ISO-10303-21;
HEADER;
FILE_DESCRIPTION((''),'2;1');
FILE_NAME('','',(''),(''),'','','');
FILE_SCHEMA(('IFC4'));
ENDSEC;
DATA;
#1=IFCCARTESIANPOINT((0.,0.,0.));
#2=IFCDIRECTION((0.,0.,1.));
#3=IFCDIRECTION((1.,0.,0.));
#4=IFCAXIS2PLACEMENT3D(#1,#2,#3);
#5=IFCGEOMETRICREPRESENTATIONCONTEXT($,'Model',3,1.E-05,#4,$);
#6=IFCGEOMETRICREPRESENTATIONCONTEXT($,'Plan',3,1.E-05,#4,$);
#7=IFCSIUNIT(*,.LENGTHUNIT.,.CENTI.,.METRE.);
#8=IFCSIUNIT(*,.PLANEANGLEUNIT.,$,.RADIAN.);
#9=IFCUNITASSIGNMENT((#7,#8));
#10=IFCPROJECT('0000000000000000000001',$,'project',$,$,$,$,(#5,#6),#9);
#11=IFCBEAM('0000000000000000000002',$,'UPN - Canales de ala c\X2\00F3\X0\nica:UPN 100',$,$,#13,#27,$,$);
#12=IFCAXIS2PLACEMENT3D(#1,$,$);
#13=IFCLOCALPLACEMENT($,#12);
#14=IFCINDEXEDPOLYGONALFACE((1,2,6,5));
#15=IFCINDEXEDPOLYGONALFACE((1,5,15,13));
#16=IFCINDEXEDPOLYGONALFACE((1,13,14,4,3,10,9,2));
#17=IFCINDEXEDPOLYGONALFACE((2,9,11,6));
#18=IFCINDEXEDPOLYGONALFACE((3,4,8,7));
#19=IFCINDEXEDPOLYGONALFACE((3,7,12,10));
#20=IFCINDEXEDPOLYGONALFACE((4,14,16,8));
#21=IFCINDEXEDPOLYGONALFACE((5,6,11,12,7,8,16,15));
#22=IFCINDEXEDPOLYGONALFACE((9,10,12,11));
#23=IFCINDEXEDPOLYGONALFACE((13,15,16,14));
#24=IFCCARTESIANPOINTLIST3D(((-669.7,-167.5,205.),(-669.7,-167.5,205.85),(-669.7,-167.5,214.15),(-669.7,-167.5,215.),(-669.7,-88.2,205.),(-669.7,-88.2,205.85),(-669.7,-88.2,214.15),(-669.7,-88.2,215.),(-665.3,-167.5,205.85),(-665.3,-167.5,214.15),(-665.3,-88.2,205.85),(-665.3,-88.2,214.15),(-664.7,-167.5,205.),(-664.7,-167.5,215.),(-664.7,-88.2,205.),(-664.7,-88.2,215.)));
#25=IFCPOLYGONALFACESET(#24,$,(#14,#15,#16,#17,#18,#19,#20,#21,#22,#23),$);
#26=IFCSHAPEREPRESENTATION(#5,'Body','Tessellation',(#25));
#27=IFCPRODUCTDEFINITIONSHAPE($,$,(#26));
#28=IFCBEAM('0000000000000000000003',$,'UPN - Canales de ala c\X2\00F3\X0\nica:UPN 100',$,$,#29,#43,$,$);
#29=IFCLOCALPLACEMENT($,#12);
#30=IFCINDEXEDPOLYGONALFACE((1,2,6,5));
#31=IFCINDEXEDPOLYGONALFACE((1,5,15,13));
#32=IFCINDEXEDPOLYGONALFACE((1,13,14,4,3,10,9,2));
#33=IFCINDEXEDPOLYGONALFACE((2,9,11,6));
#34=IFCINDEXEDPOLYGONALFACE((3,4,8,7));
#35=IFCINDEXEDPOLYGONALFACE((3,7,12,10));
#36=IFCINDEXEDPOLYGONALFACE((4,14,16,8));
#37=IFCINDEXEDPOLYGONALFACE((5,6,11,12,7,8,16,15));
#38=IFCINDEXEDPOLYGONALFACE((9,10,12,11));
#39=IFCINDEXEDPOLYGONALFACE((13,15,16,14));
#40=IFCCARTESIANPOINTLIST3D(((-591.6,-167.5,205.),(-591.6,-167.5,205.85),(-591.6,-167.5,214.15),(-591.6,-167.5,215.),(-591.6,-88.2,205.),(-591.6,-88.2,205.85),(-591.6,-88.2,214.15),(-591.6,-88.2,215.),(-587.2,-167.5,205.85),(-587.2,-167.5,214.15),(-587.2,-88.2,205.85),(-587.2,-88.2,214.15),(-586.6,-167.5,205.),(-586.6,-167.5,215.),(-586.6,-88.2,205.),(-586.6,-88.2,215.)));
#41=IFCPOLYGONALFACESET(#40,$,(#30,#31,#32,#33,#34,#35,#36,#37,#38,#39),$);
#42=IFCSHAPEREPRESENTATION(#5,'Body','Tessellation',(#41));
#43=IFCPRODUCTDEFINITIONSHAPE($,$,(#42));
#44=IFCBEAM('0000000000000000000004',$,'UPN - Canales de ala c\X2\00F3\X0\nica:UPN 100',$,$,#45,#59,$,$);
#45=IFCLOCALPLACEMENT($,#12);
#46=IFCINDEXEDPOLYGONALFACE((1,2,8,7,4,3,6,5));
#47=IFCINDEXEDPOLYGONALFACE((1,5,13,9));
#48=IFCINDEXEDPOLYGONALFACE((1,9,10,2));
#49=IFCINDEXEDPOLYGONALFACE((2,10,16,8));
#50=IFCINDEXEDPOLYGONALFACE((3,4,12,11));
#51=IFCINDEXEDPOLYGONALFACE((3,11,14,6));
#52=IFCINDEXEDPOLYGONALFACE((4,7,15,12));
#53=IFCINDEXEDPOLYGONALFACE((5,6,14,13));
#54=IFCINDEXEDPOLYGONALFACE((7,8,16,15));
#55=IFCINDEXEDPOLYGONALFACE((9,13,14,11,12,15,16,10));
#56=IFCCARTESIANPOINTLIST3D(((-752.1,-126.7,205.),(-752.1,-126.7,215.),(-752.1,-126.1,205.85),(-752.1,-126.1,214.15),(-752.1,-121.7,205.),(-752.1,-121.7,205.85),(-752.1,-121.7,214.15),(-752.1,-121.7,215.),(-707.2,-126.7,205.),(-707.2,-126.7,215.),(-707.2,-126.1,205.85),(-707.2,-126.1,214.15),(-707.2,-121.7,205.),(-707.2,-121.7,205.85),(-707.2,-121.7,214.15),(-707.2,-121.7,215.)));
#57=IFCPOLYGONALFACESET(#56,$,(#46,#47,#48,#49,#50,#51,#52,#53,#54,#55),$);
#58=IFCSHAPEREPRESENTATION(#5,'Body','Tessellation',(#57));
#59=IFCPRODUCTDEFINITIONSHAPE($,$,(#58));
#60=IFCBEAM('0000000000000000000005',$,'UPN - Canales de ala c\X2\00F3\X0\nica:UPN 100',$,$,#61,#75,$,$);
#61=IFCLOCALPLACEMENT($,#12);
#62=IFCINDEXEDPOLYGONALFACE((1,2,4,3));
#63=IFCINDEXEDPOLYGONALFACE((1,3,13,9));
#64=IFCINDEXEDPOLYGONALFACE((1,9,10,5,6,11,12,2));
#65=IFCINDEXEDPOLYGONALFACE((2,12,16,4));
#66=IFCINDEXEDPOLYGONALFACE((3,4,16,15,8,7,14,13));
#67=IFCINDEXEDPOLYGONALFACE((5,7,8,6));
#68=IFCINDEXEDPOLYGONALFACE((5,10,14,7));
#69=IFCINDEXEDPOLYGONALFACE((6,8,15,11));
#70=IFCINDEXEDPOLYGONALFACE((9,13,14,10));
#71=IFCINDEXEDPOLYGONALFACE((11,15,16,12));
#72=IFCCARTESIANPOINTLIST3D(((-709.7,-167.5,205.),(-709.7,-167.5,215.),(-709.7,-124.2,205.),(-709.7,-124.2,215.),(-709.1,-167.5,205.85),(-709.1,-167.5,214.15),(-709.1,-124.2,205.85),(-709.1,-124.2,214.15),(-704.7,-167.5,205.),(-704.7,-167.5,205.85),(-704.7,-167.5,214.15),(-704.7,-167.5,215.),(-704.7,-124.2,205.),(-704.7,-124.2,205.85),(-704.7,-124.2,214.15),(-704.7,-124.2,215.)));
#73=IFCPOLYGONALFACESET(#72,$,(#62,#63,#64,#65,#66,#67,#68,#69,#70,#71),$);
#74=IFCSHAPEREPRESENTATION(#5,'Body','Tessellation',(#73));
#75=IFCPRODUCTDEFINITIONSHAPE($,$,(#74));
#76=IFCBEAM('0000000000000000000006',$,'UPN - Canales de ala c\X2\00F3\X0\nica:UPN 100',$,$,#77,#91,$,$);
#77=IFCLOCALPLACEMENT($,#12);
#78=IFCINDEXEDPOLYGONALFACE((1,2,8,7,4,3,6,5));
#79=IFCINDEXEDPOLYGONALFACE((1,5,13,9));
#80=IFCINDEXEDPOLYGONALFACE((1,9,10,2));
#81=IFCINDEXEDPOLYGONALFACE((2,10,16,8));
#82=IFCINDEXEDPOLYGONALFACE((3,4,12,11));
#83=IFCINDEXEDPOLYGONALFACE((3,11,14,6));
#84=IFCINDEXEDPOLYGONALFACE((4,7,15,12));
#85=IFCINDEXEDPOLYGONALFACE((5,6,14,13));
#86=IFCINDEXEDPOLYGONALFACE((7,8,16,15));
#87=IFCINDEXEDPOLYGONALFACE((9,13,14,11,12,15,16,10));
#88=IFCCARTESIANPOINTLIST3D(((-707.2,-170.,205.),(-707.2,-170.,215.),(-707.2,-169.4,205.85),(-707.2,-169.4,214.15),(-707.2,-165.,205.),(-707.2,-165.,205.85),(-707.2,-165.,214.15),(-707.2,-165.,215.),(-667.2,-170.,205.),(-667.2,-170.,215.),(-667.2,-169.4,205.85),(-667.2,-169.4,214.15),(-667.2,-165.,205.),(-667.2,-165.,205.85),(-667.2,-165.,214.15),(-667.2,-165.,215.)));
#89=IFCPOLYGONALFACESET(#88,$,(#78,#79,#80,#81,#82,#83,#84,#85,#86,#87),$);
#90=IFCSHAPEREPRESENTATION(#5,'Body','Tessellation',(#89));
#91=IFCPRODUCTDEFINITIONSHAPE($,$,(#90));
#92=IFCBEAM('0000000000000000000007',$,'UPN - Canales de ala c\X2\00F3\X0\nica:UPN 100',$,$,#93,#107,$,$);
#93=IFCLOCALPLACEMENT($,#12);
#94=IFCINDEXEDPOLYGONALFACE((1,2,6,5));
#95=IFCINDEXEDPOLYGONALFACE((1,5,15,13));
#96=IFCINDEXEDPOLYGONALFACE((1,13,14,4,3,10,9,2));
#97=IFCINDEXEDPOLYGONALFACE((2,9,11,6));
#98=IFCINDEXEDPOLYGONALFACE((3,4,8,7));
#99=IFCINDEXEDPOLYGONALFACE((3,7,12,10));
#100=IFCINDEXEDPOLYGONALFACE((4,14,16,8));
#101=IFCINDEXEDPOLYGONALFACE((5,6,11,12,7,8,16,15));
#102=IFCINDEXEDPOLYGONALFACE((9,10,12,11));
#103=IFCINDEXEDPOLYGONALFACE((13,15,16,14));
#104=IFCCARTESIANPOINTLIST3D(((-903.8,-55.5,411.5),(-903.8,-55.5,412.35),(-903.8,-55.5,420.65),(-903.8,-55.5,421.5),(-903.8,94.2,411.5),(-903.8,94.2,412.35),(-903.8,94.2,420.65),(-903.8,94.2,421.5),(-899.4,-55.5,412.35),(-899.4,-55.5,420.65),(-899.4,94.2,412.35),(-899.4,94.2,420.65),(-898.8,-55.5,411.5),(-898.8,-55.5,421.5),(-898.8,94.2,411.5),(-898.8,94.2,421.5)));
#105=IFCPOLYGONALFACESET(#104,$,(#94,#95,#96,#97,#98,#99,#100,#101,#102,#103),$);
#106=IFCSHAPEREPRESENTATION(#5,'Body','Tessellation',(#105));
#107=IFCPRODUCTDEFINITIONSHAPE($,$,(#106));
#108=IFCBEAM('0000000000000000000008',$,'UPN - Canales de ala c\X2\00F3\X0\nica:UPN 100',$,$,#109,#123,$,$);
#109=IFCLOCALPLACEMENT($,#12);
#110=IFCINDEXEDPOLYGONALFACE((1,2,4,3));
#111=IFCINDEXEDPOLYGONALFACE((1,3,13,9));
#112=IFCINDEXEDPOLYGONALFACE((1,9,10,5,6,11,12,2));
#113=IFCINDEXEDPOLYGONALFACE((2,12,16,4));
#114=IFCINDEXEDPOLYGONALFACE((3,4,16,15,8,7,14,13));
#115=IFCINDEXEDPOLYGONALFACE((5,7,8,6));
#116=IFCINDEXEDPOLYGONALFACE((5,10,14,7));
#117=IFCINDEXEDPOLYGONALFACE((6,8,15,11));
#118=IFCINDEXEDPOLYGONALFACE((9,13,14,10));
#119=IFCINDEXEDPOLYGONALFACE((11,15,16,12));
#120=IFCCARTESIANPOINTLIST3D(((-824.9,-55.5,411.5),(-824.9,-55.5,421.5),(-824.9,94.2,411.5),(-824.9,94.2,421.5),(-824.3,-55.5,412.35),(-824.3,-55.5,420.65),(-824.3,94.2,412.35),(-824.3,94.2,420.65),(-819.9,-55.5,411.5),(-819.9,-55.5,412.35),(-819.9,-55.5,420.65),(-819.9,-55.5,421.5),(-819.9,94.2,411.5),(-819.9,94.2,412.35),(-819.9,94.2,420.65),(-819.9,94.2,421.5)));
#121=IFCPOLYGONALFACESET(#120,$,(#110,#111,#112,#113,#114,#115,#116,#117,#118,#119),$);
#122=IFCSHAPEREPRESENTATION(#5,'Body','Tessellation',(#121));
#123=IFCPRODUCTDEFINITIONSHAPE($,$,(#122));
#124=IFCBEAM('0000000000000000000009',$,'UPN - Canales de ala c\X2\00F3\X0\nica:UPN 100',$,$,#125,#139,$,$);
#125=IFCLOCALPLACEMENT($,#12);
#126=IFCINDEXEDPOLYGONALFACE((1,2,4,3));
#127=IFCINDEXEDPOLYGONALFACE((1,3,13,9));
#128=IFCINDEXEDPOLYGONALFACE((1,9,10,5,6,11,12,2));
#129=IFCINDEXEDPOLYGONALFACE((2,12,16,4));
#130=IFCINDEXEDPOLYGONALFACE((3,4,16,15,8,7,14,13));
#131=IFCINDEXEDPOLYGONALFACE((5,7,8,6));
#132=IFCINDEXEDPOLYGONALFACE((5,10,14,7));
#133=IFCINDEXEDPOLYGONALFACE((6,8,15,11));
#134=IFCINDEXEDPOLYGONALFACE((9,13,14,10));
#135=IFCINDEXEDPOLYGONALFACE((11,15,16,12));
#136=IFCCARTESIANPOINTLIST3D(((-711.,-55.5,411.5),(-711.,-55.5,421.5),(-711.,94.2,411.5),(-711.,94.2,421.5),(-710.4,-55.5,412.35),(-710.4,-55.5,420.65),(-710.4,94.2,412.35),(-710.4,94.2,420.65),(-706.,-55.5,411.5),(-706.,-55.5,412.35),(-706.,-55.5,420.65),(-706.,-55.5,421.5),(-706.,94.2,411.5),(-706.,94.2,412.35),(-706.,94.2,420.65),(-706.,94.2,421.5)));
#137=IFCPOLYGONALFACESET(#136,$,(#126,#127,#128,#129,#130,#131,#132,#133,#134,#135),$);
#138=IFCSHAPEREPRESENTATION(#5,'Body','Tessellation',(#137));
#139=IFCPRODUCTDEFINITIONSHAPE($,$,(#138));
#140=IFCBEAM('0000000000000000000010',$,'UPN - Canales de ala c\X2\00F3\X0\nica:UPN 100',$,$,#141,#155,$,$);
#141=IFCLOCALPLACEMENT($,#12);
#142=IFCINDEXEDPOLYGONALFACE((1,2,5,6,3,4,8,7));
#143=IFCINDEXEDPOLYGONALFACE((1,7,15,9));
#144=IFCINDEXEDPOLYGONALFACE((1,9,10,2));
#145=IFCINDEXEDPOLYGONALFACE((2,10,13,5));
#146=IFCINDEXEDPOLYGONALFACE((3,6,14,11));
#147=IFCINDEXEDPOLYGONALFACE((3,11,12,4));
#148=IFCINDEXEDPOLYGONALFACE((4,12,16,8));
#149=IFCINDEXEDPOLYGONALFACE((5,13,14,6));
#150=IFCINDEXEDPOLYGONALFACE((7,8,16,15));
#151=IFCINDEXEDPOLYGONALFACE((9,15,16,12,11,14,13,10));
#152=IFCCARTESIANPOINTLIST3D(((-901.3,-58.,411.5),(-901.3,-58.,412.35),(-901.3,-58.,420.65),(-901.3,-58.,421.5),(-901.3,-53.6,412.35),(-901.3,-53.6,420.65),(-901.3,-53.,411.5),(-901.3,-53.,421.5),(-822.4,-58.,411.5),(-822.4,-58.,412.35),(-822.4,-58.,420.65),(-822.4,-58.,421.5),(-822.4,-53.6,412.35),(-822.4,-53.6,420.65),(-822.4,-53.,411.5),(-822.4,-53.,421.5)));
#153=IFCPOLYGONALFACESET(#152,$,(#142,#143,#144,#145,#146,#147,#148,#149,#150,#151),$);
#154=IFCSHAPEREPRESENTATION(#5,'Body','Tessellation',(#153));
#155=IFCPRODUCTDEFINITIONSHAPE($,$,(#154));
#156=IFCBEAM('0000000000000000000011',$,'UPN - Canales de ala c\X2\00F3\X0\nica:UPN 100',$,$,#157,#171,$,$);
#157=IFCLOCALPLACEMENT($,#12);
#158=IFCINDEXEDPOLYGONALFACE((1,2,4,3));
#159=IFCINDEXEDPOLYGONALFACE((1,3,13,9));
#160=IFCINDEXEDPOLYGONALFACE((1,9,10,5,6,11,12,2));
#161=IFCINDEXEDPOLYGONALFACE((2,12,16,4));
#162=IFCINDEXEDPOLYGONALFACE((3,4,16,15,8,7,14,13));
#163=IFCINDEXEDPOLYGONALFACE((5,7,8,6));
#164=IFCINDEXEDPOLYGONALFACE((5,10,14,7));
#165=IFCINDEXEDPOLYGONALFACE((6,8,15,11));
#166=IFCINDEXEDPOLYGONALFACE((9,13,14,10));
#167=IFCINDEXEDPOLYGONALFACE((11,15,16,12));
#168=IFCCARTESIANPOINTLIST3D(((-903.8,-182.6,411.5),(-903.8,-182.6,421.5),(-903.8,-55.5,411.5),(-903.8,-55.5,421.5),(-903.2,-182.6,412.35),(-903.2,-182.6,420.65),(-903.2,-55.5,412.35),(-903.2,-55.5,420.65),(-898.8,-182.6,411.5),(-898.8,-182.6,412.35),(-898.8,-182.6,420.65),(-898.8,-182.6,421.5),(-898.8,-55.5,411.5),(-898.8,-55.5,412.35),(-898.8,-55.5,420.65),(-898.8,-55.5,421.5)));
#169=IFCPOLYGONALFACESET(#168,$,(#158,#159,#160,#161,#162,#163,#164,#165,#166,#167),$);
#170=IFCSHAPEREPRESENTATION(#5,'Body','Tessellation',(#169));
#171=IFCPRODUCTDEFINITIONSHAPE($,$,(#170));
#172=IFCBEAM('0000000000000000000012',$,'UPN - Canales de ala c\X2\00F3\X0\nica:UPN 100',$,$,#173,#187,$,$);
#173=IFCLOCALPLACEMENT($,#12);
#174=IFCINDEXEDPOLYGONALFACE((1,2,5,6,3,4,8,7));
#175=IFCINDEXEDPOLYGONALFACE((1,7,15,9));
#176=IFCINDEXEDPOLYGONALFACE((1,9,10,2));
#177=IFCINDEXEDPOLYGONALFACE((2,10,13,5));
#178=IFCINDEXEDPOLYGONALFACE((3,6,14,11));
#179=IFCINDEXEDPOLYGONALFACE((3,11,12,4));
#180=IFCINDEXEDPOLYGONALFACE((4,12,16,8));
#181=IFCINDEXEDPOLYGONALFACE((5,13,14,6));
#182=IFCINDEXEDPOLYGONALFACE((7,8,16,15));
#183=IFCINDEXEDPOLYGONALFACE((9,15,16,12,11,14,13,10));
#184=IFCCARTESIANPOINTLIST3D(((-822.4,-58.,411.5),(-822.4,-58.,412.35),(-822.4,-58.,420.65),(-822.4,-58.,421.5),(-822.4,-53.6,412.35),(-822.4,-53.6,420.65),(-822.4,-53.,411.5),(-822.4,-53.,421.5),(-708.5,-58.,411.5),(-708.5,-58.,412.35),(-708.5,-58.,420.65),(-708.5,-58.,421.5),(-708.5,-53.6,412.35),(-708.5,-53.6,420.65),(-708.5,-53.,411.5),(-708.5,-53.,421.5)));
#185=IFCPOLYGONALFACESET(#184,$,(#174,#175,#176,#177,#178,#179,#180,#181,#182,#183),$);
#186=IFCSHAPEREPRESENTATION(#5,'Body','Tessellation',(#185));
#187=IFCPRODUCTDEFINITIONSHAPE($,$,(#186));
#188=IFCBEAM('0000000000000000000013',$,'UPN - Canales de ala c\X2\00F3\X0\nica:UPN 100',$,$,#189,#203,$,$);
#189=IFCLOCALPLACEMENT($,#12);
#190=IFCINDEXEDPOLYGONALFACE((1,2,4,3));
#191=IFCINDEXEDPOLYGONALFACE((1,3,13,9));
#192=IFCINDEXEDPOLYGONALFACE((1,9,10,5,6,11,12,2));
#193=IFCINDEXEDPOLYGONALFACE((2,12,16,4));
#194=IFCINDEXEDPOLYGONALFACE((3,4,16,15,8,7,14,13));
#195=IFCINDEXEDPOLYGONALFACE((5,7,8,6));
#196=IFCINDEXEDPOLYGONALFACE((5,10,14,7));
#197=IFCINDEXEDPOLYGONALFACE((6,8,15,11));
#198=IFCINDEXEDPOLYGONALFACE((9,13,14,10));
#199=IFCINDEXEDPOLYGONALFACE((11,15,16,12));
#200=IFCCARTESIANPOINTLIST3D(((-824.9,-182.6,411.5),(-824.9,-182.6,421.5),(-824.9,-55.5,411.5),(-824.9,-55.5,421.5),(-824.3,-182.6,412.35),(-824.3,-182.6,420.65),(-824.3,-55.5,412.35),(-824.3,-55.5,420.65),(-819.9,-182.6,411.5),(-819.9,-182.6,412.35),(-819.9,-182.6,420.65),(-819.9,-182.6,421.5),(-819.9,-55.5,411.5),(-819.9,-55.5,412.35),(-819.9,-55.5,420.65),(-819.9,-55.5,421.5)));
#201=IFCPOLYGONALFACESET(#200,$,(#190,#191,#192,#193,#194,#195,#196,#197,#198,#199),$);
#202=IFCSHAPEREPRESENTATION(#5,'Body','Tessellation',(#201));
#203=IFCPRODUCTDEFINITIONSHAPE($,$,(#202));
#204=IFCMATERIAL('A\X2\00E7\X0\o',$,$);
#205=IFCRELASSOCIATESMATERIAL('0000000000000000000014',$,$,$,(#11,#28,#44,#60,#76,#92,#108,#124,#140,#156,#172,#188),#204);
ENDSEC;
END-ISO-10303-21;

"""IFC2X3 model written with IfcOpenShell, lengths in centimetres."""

from ifc_helpers import new_model, si_unit, frame, origin_with_axes, origin_2d_with_axis, place, context, project, u_section, extrude, material, element, save


model = new_model("IFC2X3")

# Units and contexts
model_context = context("Model", 3, precision=1e-05, world=origin_with_axes())
plan_context = context("Plan", 3, precision=1e-05, world=origin_with_axes())
ifc_project = project(units=[si_unit("LENGTHUNIT", "METRE", prefix="CENTI"), si_unit("PLANEANGLEUNIT", "RADIAN")], contexts=[model_context, plan_context])

# Shared definitions
ifc_material = material(Name="Aço")

# Beams
for number, where, z_axis, x_axis, name in (
    (1, (-667.2, -167.5, 210.0), (0.0, 1.0, 0.0), (-1.0, 0.0, 0.0), "UPN - Canales de ala cónica:UPN 100"),
    (2, (-589.1, -167.5, 210.0), (0.0, 1.0, 0.0), (-1.0, 0.0, 0.0), "UPN - Canales de ala cónica:UPN 100"),
):
    element("IfcBeam", number, at=place(None, frame(where, z_axis=z_axis, x_axis=x_axis)), material=ifc_material, Name=name, context=model_context, shape_type="SweptSolid", body=[
        extrude(u_section(Depth=10.0, FlangeWidth=5.0, WebThickness=0.6, FlangeThickness=0.85, FilletRadius=0.0, EdgeRadius=0.0, FlangeSlope=0.0, CentreOfGravityInX=0.0, at=origin_2d_with_axis()), origin_with_axes(), (0.0, 0.0, 1.0), 79.3),
    ])
beam_1_placement = place(None, frame((-707.2, -124.2, 210.0), z_axis=(-1.0, 0.0, 0.0), x_axis=(0.0, 1.0, 0.0)))
element("IfcBeam", 3, at=beam_1_placement, material=ifc_material, Name="UPN - Canales de ala cónica:UPN 100", context=model_context, shape_type="SweptSolid", body=[
    extrude(u_section(Depth=10.0, FlangeWidth=5.0, WebThickness=0.6, FlangeThickness=0.85, FilletRadius=0.0, EdgeRadius=0.0, FlangeSlope=0.0, CentreOfGravityInX=0.0, at=origin_2d_with_axis()), origin_with_axes(), (0.0, 0.0, 1.0), 44.9),
])
beam_2_placement = place(None, frame((-707.2, -167.5, 210.0), z_axis=(0.0, 1.0, 0.0), x_axis=(1.0, 0.0, 0.0)))
element("IfcBeam", 4, at=beam_2_placement, material=ifc_material, Name="UPN - Canales de ala cónica:UPN 100", context=model_context, shape_type="SweptSolid", body=[
    extrude(u_section(Depth=10.0, FlangeWidth=5.0, WebThickness=0.6, FlangeThickness=0.85, FilletRadius=0.0, EdgeRadius=0.0, FlangeSlope=0.0, CentreOfGravityInX=0.0, at=origin_2d_with_axis()), origin_with_axes(), (0.0, 0.0, 1.0), 43.3),
])
beam_3_placement = place(None, frame((-667.2, -167.5, 210.0), z_axis=(-1.0, 0.0, 0.0), x_axis=(0.0, 1.0, 0.0)))
element("IfcBeam", 5, at=beam_3_placement, material=ifc_material, Name="UPN - Canales de ala cónica:UPN 100", context=model_context, shape_type="SweptSolid", body=[
    extrude(u_section(Depth=10.0, FlangeWidth=5.0, WebThickness=0.6, FlangeThickness=0.85, FilletRadius=0.0, EdgeRadius=0.0, FlangeSlope=0.0, CentreOfGravityInX=0.0, at=origin_2d_with_axis()), origin_with_axes(), (0.0, 0.0, 1.0), 40.0),
])
for number, where, z_axis, x_axis, name in (
    (6, (-901.3, -55.5, 416.5), (0.0, 1.0, 0.0), (-1.0, 0.0, 0.0), "UPN - Canales de ala cónica:UPN 100"),
    (7, (-822.4, -55.5, 416.5), (0.0, 1.0, 0.0), (1.0, 0.0, 0.0), "UPN - Canales de ala cónica:UPN 100"),
    (8, (-708.5, -55.5, 416.5), (0.0, 1.0, 0.0), (1.0, 0.0, 0.0), "UPN - Canales de ala cónica:UPN 100"),
):
    element("IfcBeam", number, at=place(None, frame(where, z_axis=z_axis, x_axis=x_axis)), material=ifc_material, Name=name, context=model_context, shape_type="SweptSolid", body=[
        extrude(u_section(Depth=10.0, FlangeWidth=5.0, WebThickness=0.6, FlangeThickness=0.85, FilletRadius=0.0, EdgeRadius=0.0, FlangeSlope=0.0, CentreOfGravityInX=0.0, at=origin_2d_with_axis()), origin_with_axes(), (0.0, 0.0, 1.0), 149.7),
    ])
beam_4_placement = place(None, frame((-822.4, -55.5, 416.5), z_axis=(-1.0, 0.0, 0.0), x_axis=(0.0, -1.0, 0.0)))
element("IfcBeam", 9, at=beam_4_placement, material=ifc_material, Name="UPN - Canales de ala cónica:UPN 100", context=model_context, shape_type="SweptSolid", body=[
    extrude(u_section(Depth=10.0, FlangeWidth=5.0, WebThickness=0.6, FlangeThickness=0.85, FilletRadius=0.0, EdgeRadius=0.0, FlangeSlope=0.0, CentreOfGravityInX=0.0, at=origin_2d_with_axis()), origin_with_axes(), (0.0, 0.0, 1.0), 78.9),
])
beam_5_placement = place(None, frame((-901.3, -182.6, 416.5), z_axis=(0.0, 1.0, 0.0), x_axis=(1.0, 0.0, 0.0)))
element("IfcBeam", 10, at=beam_5_placement, material=ifc_material, Name="UPN - Canales de ala cónica:UPN 100", context=model_context, shape_type="SweptSolid", body=[
    extrude(u_section(Depth=10.0, FlangeWidth=5.0, WebThickness=0.6, FlangeThickness=0.85, FilletRadius=0.0, EdgeRadius=0.0, FlangeSlope=0.0, CentreOfGravityInX=0.0, at=origin_2d_with_axis()), origin_with_axes(), (0.0, 0.0, 1.0), 127.1),
])
beam_6_placement = place(None, frame((-708.5, -55.5, 416.5), z_axis=(-1.0, 0.0, 0.0), x_axis=(0.0, -1.0, 0.0)))
element("IfcBeam", 11, at=beam_6_placement, material=ifc_material, Name="UPN - Canales de ala cónica:UPN 100", context=model_context, shape_type="SweptSolid", body=[
    extrude(u_section(Depth=10.0, FlangeWidth=5.0, WebThickness=0.6, FlangeThickness=0.85, FilletRadius=0.0, EdgeRadius=0.0, FlangeSlope=0.0, CentreOfGravityInX=0.0, at=origin_2d_with_axis()), origin_with_axes(), (0.0, 0.0, 1.0), 113.9),
])
for number, where, z_axis, x_axis, name in (
    (12, (-822.4, -182.6, 416.5), (0.0, 1.0, 0.0), (1.0, 0.0, 0.0), "UPN - Canales de ala cónica:UPN 100"),
):
    element("IfcBeam", number, at=place(None, frame(where, z_axis=z_axis, x_axis=x_axis)), material=ifc_material, Name=name, context=model_context, shape_type="SweptSolid", body=[
        extrude(u_section(Depth=10.0, FlangeWidth=5.0, WebThickness=0.6, FlangeThickness=0.85, FilletRadius=0.0, EdgeRadius=0.0, FlangeSlope=0.0, CentreOfGravityInX=0.0, at=origin_2d_with_axis()), origin_with_axes(), (0.0, 0.0, 1.0), 127.1),
    ])

save(model, "model.ifc")
